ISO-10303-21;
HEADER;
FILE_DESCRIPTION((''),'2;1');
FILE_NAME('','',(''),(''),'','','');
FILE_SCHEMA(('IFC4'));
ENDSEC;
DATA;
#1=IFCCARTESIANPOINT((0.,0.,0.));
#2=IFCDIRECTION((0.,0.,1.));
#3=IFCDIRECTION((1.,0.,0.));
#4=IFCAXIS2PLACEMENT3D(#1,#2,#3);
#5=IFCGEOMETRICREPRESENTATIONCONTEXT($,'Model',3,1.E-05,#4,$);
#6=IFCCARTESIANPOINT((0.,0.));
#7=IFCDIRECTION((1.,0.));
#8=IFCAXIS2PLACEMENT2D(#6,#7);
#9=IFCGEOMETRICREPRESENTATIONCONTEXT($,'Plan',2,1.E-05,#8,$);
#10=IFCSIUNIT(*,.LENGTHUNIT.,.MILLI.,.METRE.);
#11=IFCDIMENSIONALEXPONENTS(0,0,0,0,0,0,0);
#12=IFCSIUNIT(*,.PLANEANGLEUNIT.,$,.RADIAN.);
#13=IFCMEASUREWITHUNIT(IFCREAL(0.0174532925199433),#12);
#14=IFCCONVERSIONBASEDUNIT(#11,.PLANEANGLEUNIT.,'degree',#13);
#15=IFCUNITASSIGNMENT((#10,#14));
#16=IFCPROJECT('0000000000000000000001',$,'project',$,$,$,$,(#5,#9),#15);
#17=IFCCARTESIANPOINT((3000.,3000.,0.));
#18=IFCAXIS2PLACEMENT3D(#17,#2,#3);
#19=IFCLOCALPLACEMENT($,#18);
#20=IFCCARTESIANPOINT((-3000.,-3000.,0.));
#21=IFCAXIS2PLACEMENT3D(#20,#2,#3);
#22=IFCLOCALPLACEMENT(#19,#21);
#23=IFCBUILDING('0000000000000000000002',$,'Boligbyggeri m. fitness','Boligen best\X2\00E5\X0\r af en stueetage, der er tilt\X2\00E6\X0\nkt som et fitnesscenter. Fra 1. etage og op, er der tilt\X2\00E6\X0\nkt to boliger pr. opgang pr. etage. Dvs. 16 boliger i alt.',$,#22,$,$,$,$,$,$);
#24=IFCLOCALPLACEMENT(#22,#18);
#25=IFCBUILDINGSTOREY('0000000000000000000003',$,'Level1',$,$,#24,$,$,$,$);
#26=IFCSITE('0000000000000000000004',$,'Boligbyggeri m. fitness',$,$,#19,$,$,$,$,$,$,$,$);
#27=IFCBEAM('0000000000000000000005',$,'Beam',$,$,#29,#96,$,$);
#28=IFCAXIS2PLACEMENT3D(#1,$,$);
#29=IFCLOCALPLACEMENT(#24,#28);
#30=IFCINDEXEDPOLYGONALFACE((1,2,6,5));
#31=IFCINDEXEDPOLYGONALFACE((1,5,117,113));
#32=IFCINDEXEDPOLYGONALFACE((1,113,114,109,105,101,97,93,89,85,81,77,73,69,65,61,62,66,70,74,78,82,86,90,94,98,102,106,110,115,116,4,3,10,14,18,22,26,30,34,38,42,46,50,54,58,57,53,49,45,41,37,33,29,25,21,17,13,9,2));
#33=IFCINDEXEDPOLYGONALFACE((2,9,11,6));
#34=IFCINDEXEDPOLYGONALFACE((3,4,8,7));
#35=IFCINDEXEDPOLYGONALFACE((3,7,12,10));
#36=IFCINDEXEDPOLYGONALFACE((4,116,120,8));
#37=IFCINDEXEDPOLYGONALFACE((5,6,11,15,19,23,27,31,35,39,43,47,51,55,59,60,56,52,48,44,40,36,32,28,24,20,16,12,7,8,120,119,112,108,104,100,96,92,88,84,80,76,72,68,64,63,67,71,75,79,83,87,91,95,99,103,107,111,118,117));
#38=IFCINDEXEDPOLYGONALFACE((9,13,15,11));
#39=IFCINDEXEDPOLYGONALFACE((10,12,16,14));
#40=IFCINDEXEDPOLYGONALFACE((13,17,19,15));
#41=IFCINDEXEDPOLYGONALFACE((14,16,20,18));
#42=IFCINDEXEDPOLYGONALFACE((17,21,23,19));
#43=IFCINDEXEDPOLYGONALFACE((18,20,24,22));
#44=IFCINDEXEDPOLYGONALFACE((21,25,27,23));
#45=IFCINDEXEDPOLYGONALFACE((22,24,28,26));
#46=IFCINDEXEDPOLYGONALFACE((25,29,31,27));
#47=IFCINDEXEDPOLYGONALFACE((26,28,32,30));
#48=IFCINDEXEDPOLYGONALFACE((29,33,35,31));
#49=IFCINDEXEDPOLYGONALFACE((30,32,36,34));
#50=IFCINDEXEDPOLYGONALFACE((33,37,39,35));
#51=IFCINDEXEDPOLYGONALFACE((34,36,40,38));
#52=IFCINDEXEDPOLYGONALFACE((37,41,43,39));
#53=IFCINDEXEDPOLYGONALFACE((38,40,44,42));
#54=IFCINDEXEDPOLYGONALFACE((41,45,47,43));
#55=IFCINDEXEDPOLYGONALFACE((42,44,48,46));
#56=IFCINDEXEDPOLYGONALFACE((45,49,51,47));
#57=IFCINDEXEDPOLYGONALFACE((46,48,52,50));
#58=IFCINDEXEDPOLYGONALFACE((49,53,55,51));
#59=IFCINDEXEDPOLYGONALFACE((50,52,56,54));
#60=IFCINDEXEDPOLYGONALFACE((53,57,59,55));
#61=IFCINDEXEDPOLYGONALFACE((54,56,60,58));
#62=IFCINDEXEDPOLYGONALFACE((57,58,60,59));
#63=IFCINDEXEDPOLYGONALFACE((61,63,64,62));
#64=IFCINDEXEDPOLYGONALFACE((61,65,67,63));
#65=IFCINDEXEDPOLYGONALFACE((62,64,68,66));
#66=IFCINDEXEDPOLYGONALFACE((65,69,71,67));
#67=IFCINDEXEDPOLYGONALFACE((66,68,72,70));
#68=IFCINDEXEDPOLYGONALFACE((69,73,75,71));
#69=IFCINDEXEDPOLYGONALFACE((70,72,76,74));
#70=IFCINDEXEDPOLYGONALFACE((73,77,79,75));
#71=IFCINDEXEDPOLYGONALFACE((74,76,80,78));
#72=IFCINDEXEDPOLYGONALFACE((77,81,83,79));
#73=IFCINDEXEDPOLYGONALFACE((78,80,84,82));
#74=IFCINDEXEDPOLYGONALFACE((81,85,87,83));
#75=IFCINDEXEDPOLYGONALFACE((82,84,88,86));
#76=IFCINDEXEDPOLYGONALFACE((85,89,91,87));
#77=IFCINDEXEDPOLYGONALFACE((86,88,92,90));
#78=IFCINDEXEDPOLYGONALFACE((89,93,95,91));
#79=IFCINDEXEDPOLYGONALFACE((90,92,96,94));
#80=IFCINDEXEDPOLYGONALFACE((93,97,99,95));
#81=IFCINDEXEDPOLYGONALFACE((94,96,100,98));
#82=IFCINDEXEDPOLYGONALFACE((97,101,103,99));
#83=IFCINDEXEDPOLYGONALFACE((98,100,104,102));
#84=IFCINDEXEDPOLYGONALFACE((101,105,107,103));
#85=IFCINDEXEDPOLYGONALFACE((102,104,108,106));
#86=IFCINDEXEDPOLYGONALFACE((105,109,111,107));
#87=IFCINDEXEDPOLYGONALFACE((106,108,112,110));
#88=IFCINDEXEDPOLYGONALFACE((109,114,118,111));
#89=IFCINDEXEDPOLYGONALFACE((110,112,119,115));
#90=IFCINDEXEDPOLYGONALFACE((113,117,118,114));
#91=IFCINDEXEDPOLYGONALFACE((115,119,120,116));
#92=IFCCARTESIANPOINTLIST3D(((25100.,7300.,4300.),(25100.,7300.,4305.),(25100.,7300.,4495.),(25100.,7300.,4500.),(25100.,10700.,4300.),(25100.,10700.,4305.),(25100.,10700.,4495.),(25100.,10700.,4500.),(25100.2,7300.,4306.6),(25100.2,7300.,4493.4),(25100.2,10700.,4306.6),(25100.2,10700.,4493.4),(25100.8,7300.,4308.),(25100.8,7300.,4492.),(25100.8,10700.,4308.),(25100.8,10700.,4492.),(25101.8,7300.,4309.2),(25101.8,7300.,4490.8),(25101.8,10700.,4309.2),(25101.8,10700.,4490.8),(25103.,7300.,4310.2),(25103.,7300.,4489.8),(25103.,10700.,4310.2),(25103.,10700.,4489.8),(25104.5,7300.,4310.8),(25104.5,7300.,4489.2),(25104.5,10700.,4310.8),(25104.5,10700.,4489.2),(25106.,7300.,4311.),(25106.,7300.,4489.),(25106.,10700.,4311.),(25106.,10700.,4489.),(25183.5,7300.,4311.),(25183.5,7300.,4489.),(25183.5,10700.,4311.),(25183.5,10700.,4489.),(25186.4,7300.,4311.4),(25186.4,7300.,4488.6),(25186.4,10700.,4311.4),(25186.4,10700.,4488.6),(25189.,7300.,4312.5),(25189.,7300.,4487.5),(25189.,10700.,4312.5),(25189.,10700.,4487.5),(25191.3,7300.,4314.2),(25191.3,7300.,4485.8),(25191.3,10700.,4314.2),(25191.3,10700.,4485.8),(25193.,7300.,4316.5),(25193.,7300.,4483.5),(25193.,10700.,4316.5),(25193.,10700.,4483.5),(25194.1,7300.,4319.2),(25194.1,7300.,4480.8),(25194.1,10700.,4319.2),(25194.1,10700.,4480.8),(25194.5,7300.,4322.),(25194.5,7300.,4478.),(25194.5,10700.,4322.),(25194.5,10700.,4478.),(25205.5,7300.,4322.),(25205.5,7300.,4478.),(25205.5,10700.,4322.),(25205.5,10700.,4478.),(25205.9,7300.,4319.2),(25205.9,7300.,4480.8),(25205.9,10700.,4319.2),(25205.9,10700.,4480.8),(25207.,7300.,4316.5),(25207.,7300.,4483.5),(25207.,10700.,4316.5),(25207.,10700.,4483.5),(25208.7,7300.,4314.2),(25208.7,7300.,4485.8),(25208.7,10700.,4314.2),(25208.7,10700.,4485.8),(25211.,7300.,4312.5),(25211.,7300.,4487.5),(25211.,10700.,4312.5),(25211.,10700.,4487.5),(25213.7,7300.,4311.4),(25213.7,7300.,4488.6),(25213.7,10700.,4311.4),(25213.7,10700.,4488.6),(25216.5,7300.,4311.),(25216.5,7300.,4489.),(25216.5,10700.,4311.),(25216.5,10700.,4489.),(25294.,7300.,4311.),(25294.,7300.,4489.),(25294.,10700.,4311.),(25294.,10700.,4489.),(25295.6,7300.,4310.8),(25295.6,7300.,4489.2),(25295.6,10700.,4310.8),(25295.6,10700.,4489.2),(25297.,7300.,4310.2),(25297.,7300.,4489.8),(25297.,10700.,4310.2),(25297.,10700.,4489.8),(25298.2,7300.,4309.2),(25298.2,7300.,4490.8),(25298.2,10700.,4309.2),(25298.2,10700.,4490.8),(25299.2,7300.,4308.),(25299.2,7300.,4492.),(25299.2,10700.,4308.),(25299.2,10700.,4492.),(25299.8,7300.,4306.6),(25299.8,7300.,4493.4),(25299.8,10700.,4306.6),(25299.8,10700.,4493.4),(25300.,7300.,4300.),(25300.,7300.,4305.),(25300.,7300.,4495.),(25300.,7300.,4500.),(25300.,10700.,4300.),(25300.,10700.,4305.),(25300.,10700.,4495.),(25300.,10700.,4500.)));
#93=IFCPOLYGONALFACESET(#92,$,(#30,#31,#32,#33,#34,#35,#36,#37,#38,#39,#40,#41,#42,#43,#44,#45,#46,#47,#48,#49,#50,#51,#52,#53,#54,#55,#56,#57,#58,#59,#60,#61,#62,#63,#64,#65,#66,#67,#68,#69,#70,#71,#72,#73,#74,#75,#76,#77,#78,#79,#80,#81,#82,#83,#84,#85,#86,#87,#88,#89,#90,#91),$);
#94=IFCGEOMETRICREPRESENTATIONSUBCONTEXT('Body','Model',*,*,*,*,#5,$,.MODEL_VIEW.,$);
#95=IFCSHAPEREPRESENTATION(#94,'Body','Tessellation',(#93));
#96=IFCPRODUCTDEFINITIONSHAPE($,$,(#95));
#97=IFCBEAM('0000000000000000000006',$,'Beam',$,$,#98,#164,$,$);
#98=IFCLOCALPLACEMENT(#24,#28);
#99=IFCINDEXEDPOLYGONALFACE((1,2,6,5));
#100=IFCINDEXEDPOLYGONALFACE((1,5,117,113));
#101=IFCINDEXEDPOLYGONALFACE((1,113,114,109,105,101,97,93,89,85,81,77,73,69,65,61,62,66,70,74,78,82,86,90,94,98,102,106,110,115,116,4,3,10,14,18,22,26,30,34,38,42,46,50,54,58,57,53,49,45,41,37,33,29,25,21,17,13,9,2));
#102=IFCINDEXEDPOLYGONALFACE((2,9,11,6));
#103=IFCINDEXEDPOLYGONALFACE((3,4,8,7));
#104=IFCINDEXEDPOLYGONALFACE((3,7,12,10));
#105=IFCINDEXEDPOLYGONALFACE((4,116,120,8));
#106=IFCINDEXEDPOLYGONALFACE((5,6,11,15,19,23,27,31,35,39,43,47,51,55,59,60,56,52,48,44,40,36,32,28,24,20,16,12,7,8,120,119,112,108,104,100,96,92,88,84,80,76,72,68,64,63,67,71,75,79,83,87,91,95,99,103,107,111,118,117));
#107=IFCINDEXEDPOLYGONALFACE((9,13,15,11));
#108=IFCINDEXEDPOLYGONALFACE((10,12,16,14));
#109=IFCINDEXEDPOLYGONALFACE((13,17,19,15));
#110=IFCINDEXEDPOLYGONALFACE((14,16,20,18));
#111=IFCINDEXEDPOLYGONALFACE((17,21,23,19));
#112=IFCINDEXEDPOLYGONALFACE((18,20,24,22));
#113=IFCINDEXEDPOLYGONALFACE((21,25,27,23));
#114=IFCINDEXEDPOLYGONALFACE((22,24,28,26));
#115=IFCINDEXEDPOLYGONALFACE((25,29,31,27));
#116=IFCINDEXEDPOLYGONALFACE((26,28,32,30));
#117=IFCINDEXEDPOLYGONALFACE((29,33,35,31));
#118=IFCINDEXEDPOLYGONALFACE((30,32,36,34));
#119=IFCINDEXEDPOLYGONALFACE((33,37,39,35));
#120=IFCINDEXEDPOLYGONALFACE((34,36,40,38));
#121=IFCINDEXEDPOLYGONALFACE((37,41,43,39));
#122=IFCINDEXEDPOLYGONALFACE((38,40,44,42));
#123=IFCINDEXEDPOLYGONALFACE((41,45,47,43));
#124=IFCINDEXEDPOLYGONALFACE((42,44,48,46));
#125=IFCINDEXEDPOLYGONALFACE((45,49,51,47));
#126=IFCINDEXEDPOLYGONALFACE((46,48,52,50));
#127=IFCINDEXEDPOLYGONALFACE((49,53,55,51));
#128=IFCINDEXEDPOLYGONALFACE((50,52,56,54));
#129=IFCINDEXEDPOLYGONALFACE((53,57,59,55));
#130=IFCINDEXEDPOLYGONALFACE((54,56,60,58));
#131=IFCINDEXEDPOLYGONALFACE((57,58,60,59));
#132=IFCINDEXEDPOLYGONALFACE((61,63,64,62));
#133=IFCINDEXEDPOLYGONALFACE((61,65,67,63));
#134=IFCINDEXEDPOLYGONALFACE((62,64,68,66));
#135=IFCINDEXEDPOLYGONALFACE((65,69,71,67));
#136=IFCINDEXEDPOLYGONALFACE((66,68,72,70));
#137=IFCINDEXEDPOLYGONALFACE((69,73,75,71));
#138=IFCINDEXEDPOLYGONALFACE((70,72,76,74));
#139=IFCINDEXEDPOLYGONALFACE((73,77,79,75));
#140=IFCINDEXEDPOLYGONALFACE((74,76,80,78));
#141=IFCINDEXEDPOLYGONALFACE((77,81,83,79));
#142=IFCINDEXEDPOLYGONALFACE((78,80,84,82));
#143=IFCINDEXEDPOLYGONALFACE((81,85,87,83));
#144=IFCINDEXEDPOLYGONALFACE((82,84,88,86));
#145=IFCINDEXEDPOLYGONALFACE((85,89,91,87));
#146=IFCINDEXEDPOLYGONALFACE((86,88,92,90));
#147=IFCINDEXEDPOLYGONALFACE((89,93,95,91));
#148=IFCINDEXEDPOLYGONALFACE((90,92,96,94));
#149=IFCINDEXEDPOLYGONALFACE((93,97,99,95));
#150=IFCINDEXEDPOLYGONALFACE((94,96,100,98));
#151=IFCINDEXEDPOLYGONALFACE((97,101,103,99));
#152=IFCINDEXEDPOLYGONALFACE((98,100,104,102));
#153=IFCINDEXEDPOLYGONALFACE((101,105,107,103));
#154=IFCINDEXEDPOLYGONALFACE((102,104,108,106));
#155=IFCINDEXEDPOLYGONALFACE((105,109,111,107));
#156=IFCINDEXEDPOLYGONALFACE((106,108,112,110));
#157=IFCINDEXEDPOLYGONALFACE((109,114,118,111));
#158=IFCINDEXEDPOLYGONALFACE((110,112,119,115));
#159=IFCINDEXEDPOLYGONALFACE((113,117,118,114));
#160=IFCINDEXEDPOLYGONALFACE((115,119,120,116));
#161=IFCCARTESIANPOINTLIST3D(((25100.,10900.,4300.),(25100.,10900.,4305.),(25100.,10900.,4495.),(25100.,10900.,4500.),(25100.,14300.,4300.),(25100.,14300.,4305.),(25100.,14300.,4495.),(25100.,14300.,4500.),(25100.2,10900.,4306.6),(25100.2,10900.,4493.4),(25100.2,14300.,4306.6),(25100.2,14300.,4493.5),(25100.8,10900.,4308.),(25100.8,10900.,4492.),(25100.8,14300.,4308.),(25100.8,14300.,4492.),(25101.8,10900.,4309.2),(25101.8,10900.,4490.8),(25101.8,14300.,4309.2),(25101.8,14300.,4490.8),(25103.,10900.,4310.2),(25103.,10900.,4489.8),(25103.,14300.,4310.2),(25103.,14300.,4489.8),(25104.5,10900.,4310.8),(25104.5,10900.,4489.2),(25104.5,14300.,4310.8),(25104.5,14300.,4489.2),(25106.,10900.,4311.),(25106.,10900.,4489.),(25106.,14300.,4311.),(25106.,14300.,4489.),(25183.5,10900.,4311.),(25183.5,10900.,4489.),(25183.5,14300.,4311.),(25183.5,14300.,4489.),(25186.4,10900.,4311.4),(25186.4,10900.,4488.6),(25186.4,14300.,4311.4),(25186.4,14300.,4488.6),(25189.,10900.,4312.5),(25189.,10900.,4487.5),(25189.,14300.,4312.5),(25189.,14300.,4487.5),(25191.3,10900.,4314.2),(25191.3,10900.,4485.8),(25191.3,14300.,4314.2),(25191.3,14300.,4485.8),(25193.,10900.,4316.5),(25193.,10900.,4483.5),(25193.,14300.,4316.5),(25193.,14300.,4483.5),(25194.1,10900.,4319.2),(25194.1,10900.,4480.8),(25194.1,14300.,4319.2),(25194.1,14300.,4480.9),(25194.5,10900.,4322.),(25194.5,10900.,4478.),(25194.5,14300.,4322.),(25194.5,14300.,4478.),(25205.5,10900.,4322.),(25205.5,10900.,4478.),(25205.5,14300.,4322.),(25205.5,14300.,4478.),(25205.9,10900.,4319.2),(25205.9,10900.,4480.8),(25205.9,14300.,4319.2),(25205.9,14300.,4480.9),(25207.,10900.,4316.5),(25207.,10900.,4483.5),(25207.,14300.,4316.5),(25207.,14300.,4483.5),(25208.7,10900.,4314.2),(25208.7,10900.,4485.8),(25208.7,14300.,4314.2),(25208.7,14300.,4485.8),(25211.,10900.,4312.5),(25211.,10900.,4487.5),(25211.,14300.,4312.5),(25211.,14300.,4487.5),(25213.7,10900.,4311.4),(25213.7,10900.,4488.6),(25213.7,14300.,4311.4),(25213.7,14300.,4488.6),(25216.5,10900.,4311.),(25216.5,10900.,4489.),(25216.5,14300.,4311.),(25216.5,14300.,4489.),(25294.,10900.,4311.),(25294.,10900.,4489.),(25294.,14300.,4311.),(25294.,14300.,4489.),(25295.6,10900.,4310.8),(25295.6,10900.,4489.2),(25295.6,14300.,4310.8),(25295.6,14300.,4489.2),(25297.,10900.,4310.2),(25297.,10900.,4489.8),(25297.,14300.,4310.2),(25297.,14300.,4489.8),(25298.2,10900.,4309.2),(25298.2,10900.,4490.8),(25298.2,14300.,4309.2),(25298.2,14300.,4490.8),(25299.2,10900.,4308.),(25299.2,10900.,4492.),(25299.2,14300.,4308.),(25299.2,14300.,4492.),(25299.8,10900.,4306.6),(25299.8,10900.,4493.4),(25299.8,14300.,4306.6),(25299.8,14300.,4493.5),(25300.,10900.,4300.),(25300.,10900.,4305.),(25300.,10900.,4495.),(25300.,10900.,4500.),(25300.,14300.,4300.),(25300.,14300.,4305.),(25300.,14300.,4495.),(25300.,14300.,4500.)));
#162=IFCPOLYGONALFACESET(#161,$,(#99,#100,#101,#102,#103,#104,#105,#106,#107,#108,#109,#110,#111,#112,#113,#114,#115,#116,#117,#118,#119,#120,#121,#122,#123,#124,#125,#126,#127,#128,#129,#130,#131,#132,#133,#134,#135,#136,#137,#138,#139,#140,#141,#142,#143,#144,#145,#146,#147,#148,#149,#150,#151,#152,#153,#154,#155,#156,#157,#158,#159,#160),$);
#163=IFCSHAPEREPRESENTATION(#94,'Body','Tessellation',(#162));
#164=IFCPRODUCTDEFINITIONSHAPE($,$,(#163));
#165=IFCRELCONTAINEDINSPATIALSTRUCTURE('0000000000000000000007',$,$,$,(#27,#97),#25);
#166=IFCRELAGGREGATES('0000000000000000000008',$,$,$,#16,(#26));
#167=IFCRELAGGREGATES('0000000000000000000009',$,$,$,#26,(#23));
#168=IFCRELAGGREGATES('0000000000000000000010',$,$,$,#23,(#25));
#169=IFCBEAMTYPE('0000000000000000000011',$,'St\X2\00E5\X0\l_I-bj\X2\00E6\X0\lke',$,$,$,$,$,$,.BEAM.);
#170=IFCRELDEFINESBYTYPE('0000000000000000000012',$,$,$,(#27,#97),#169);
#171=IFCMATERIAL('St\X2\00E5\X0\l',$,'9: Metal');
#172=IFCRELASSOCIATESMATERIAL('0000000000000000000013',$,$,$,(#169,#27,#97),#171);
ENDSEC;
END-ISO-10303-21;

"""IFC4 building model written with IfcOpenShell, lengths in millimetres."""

from ifc_helpers import new_model, entity, si_unit, converted_unit, frame, origin_with_axes, origin_2d_with_axis, place, context, subcontext, project, spatial, i_section, extrude, material, material_profile, profile_set, profile_usage, type_object, element, save


model = new_model("IFC4")

# Units and contexts
model_context = context("Model", 3, precision=1e-05, world=origin_with_axes())
plan_context = context("Plan", 2, precision=1e-05, world=origin_2d_with_axis())
body_context = subcontext(model_context, "Body", "Model", "MODEL_VIEW")
ifc_project = project(units=[si_unit("LENGTHUNIT", "METRE", prefix="MILLI"), converted_unit("PLANEANGLEUNIT", "degree", entity("IfcReal", 0.0174532925199433), si_unit("PLANEANGLEUNIT", "RADIAN"), dimensions=[0, 0, 0, 0, 0, 0, 0])], contexts=[model_context, plan_context])

# Site, building, storey
site_placement = place(None, frame((3000.0, 3000.0, 0.0), z_axis=(0.0, 0.0, 1.0), x_axis=(1.0, 0.0, 0.0)))
site = spatial("IfcSite", under=ifc_project, at=site_placement, Name="Boligbyggeri m. fitness")
building_placement = place(site_placement, frame((-3000.0, -3000.0, 0.0), z_axis=(0.0, 0.0, 1.0), x_axis=(1.0, 0.0, 0.0)))
building = spatial("IfcBuilding", under=site, at=building_placement, Name="Boligbyggeri m. fitness", Description="Boligen består af en stueetage, der er tiltænkt som et fitnesscenter. Fra 1. etage og op, er der tiltænkt to boliger pr. opgang pr. etage. Dvs. 16 boliger i alt.")
storey_placement = place(building_placement, frame((3000.0, 3000.0, 0.0), z_axis=(0.0, 0.0, 1.0), x_axis=(1.0, 0.0, 0.0)))
storey = spatial("IfcBuildingStorey", under=building, at=storey_placement, Name="Level1")

# Beams
ifc_material_1 = material(Name="Stål", Category="9: Metal")
ifc_material_profile_1 = material_profile(ifc_material_1, i_section(OverallWidth=200.0, OverallDepth=200.0, WebThickness=11.0, FlangeThickness=11.0, FilletRadius=11.0, FlangeEdgeRadius=6.0), Name="Stål", Category="9: Metal")
ifc_profile_set_1 = profile_set([ifc_material_profile_1], Name="NY_I-Profil")
beam_type = type_object("IfcBeamType", Name="Stål_I-bjælke", PredefinedType="BEAM", material=ifc_profile_set_1)
ifc_profile_usage_1 = profile_usage(ifc_profile_set_1, cardinal=9)
beam_1_placement = place(storey_placement, frame((25300.0, 7300.0, 4500.0), z_axis=(0.0, 1.0, 0.0), x_axis=(-1.0, 0.0, 0.0)))
element("IfcBeam", 1, at=beam_1_placement, inside=storey, type_object=beam_type, material=ifc_profile_usage_1, Name="Beam", context=body_context, shape_type="SweptSolid", body=[
    extrude(i_section(OverallWidth=200.0, OverallDepth=200.0, WebThickness=11.0, FlangeThickness=11.0, FilletRadius=11.0, FlangeEdgeRadius=6.0), frame((100.0, -100.0, 0.0), z_axis=(0.0, 0.0, 1.0), x_axis=(1.0, 0.0, 0.0)), (0.0, 0.0, 1.0), 3400.0),
])
ifc_profile_usage_2 = profile_usage(ifc_profile_set_1, cardinal=9)
beam_2_placement = place(storey_placement, frame((25300.0, 10900.0, 4500.0), z_axis=(0.0, 1.0, 0.0), x_axis=(-1.0, 0.0, 0.0)))
element("IfcBeam", 2, at=beam_2_placement, inside=storey, type_object=beam_type, material=ifc_profile_usage_2, Name="Beam", context=body_context, shape_type="SweptSolid", body=[
    extrude(i_section(OverallWidth=200.0, OverallDepth=200.0, WebThickness=11.0, FlangeThickness=11.0, FilletRadius=11.0, FlangeEdgeRadius=6.0), frame((100.0, -100.0, 0.0), z_axis=(0.0, 0.0, 1.0), x_axis=(1.0, 0.0, 0.0)), (0.0, 0.0, 1.0), 3400.0),
])

save(model, "model.ifc")
